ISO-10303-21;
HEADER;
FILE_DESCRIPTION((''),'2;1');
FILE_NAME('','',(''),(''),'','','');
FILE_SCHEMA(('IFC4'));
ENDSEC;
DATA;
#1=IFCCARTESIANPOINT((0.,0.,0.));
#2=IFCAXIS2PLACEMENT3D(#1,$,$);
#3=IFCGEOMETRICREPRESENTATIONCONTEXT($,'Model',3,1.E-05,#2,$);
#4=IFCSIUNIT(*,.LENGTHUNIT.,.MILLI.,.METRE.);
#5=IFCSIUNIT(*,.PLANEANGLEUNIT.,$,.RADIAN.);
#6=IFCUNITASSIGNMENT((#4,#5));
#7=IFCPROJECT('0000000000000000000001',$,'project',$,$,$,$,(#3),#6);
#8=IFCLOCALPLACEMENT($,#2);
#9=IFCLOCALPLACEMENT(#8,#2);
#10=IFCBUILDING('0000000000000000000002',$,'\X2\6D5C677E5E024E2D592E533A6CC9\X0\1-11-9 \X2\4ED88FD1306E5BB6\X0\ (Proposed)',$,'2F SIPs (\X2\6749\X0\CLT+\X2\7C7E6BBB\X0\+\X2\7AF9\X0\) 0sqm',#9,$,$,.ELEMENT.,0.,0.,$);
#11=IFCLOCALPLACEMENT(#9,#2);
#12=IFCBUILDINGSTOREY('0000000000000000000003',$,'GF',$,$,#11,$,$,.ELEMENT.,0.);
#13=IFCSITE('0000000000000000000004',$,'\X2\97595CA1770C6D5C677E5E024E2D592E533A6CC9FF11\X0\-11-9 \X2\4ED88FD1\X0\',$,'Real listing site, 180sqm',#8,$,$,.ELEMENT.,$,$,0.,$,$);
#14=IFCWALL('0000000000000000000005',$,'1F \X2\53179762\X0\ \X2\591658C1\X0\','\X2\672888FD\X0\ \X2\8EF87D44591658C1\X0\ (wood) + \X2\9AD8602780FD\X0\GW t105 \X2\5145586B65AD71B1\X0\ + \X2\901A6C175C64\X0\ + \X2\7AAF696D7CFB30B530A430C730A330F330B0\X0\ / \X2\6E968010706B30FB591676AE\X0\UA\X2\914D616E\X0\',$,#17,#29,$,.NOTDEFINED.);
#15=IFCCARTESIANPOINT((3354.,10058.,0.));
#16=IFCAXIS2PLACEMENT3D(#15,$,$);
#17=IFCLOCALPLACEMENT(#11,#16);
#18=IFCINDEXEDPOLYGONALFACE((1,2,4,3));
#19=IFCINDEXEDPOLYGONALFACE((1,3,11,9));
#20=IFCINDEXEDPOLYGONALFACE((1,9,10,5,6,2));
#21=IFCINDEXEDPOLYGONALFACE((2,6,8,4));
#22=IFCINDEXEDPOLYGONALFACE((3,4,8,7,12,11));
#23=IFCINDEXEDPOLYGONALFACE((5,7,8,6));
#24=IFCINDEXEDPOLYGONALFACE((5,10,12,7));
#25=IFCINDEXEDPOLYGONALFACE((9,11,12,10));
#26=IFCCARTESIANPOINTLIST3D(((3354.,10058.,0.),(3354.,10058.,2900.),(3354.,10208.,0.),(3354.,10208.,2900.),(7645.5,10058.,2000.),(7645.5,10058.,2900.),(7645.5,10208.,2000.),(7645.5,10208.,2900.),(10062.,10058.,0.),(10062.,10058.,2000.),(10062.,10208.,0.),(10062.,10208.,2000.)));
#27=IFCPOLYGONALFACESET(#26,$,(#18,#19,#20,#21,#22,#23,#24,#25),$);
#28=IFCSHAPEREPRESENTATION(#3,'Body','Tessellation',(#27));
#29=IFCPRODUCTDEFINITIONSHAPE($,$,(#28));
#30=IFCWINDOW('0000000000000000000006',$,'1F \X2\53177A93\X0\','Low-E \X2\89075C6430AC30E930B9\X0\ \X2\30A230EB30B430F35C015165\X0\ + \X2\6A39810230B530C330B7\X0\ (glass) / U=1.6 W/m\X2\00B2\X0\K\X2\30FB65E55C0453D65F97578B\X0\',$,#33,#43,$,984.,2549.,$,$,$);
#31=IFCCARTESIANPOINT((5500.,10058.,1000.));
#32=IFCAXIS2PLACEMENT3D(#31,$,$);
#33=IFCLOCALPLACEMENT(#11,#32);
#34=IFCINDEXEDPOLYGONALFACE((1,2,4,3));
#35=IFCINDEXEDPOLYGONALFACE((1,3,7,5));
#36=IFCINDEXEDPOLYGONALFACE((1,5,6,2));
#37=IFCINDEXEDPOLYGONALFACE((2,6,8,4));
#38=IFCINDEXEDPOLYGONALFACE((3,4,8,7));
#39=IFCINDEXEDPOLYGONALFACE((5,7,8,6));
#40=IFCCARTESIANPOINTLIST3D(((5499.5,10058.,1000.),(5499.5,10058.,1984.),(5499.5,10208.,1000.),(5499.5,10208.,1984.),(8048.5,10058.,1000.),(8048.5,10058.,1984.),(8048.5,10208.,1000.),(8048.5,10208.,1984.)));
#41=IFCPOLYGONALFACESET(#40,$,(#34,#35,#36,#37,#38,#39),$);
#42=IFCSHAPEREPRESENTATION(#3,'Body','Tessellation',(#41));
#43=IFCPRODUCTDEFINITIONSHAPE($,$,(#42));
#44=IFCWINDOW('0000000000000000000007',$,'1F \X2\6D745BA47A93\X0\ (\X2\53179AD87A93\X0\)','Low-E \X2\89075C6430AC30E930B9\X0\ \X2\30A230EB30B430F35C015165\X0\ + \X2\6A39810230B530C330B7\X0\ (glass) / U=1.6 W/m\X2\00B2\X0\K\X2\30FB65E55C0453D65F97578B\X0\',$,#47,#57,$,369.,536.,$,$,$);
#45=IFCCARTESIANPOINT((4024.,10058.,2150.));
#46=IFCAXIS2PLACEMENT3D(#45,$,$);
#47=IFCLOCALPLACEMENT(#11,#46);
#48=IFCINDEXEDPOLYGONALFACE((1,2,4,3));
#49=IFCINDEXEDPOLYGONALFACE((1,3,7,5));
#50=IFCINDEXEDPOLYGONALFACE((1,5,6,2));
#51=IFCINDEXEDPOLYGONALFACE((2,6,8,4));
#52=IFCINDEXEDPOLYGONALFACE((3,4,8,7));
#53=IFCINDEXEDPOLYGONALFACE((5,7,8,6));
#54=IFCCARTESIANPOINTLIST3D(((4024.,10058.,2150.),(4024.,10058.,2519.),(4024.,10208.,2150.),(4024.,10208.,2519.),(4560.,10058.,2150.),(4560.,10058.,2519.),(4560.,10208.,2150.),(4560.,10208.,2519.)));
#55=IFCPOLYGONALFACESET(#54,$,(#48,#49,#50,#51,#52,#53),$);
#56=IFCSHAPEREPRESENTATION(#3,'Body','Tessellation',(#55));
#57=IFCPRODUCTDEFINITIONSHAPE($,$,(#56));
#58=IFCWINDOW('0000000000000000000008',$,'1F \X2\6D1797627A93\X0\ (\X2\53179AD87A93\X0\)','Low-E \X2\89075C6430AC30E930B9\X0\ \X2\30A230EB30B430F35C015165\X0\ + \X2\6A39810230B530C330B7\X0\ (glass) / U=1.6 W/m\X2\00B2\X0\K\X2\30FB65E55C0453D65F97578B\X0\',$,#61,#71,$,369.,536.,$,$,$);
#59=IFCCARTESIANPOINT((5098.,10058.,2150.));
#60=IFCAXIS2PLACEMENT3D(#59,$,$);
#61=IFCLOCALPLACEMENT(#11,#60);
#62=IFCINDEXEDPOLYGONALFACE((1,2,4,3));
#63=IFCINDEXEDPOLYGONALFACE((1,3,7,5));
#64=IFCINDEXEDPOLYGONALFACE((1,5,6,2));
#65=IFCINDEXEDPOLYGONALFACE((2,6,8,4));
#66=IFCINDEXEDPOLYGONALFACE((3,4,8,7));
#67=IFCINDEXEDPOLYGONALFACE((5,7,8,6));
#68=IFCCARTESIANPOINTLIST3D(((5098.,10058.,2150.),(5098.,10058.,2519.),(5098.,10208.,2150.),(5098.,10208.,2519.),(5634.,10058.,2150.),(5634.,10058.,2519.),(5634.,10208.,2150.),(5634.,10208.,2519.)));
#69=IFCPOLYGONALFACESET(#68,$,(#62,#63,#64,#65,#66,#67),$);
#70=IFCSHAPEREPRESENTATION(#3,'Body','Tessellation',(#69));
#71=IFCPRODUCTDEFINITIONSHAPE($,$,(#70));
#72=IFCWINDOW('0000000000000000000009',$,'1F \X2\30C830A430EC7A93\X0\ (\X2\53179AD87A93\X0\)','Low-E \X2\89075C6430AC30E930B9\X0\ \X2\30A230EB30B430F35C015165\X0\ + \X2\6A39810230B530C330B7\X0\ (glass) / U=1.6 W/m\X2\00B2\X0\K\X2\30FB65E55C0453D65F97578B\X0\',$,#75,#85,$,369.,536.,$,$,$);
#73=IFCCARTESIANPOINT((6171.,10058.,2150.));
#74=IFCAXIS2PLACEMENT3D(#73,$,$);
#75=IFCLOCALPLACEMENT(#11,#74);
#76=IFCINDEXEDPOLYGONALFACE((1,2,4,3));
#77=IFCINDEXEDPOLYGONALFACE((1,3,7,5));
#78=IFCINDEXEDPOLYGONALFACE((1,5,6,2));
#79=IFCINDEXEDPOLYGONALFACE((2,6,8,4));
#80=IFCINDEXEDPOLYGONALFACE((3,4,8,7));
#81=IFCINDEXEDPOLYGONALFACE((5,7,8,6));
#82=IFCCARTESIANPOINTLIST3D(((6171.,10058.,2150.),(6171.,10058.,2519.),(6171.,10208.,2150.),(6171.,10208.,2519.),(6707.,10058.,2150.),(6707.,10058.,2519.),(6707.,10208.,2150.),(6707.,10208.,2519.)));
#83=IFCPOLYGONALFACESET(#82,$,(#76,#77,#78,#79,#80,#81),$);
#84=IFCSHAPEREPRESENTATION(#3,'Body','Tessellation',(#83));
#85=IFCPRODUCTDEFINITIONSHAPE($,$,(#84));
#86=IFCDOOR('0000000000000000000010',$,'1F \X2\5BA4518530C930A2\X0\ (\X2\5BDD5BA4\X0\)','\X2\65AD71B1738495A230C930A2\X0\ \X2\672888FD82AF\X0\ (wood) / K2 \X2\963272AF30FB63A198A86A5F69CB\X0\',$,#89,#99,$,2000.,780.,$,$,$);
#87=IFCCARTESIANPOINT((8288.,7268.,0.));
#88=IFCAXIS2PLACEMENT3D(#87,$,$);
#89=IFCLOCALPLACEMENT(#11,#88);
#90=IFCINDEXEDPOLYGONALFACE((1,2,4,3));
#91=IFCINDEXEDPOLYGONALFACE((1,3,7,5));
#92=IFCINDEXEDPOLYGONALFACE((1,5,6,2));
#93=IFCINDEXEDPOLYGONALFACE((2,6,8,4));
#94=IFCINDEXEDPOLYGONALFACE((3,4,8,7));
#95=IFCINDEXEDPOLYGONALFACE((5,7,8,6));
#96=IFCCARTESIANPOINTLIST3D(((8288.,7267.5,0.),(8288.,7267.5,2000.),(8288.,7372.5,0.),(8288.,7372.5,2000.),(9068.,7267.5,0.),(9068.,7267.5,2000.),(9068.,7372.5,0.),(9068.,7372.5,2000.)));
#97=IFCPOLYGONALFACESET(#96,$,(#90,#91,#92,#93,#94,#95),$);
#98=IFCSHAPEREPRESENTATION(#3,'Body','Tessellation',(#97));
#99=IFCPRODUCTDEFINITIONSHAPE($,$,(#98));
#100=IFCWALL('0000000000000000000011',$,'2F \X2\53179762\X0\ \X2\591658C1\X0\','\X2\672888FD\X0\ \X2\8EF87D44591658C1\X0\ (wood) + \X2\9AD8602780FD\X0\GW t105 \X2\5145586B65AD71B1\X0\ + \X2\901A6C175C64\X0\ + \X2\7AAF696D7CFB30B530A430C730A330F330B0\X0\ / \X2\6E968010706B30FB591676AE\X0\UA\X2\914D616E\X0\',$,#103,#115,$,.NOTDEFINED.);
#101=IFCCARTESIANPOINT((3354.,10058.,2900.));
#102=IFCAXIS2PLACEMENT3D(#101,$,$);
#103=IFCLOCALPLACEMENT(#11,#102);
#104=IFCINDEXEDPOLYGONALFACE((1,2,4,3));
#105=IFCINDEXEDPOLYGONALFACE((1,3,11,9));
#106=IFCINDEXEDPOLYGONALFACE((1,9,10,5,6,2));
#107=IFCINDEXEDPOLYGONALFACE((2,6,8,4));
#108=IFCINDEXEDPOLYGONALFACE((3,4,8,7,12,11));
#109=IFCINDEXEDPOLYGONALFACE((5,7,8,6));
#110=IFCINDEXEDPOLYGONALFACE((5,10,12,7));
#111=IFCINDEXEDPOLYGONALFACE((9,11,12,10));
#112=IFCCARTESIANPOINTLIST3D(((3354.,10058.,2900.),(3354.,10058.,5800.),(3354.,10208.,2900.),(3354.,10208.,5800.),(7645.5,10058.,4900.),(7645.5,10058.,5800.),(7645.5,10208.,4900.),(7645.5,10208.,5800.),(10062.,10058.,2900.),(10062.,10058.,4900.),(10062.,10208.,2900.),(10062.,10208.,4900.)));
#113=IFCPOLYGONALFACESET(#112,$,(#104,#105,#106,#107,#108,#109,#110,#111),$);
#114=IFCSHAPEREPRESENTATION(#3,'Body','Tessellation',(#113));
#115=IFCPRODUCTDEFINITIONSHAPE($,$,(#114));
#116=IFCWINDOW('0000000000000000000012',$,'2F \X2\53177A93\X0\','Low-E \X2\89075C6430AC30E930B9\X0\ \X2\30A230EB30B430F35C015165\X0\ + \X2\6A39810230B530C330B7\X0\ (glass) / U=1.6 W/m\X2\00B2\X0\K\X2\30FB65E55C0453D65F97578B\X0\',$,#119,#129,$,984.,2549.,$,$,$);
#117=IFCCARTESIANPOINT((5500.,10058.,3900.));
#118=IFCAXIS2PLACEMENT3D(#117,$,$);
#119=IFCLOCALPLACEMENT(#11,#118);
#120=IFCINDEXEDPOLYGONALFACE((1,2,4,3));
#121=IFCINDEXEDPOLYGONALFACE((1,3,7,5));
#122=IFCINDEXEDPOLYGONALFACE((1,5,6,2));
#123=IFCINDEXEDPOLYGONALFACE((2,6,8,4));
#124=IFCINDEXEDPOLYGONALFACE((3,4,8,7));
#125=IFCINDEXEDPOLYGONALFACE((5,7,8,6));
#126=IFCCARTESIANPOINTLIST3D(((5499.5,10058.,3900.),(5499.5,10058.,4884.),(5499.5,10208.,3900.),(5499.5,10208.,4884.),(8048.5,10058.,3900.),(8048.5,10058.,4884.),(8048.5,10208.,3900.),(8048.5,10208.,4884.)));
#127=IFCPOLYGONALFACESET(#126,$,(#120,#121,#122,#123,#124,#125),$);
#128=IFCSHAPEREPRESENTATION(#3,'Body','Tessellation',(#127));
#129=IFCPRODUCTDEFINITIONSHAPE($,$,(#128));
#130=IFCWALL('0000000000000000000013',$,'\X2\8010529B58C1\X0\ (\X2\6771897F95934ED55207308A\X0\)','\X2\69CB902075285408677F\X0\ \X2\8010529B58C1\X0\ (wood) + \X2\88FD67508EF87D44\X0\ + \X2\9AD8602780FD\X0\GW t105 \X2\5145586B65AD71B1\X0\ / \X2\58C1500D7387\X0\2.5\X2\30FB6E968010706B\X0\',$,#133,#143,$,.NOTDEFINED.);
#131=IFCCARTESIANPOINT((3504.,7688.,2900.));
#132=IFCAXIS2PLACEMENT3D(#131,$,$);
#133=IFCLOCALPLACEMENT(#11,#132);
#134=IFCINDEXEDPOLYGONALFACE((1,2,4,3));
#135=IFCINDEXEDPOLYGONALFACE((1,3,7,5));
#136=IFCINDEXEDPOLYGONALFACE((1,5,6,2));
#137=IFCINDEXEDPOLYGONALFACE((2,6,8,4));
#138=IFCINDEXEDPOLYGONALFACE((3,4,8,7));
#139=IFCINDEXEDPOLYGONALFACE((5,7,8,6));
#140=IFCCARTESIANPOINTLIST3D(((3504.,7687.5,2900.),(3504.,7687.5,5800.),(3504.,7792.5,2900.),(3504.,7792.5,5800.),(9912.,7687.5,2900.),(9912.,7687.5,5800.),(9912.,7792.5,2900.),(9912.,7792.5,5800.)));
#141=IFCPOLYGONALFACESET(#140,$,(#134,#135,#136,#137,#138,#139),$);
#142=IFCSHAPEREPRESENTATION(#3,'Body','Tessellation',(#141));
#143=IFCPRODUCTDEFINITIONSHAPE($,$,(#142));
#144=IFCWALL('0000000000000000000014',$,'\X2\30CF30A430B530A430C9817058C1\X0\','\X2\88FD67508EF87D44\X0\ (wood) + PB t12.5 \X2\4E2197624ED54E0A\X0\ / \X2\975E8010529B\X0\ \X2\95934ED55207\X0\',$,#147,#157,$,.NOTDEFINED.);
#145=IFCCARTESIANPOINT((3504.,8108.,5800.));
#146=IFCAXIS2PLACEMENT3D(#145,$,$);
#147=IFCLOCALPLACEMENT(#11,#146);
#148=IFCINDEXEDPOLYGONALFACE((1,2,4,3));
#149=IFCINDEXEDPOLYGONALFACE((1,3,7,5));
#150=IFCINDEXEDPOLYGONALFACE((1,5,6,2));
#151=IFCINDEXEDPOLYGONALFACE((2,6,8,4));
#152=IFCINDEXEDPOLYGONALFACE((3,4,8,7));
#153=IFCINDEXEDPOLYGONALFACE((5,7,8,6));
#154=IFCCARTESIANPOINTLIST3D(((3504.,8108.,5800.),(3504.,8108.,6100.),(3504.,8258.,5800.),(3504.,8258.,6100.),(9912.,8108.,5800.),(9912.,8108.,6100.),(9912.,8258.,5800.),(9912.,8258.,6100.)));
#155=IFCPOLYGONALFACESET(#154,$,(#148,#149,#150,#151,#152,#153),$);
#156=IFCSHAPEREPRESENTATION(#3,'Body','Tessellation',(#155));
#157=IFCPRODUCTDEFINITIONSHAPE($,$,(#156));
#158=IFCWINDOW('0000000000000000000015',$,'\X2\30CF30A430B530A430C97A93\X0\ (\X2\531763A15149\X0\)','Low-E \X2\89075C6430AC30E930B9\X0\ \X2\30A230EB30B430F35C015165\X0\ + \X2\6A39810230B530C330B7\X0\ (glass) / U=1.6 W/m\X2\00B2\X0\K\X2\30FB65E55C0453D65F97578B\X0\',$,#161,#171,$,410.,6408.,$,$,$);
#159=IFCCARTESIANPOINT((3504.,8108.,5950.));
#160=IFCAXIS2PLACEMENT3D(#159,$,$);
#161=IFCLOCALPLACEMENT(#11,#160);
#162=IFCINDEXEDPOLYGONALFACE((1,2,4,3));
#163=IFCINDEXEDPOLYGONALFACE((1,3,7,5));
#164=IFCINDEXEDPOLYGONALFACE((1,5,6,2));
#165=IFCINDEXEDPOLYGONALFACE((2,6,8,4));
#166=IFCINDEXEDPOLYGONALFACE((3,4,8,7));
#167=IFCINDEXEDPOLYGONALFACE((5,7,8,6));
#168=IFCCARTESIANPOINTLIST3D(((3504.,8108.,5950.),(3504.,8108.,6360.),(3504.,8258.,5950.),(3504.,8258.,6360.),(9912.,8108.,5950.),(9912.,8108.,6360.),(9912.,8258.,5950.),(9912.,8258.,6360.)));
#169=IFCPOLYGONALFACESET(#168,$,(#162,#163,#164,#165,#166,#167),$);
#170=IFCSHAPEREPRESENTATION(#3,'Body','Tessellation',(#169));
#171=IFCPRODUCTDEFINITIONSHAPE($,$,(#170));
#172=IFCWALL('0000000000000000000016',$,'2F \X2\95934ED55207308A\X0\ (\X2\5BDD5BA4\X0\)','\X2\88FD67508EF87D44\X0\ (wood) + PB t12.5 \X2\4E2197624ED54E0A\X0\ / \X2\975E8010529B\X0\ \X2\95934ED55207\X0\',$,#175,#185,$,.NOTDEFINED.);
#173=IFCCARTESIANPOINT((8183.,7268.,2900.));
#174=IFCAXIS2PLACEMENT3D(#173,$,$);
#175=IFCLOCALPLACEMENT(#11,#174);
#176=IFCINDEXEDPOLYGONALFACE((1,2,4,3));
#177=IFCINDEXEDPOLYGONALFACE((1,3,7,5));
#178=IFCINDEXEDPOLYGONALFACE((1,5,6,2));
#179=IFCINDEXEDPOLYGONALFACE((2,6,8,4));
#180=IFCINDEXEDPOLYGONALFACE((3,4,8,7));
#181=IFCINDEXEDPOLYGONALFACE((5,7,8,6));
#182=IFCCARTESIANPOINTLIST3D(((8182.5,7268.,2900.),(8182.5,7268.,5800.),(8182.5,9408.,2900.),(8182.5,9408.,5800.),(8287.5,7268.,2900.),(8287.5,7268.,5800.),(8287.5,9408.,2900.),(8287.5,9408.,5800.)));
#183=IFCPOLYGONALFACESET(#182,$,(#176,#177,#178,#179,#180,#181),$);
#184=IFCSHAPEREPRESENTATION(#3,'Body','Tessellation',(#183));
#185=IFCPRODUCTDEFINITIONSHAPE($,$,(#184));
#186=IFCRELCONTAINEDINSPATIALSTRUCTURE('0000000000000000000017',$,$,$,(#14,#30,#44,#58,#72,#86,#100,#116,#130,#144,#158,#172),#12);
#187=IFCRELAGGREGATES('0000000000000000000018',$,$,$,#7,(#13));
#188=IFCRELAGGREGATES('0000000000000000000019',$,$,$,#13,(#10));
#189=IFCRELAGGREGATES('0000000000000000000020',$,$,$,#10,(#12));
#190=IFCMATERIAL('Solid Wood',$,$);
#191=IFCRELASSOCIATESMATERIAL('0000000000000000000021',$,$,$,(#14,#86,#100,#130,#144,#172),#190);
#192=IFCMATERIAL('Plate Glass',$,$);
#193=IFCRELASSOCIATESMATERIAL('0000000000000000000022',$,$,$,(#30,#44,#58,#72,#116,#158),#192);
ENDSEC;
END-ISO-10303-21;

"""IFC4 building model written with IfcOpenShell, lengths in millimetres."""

from ifc_helpers import new_model, si_unit, frame, frame_2d, origin, place, context, project, spatial, rectangle, extrude, material, element, fill, save


model = new_model("IFC4")

# Units and contexts
model_context = context("Model", 3, precision=1e-05, world=origin())
ifc_project = project(units=[si_unit("LENGTHUNIT", "METRE", prefix="MILLI"), si_unit("PLANEANGLEUNIT", "RADIAN")], contexts=[model_context])

# Site, building, storey
site_placement = place(None, origin())
site = spatial("IfcSite", under=ifc_project, at=site_placement, Name="静岡県浜松市中央区泉１-11-9 付近", ObjectType="Real listing site, 180sqm", CompositionType="ELEMENT", RefElevation=0.0)
building_placement = place(site_placement, origin())
building = spatial("IfcBuilding", under=site, at=building_placement, Name="浜松市中央区泉1-11-9 付近の家 (Proposed)", ObjectType="2F SIPs (杉CLT+籾殻+竹) 0sqm", CompositionType="ELEMENT", ElevationOfRefHeight=0.0, ElevationOfTerrain=0.0)
storey_placement = place(building_placement, origin())
storey = spatial("IfcBuildingStorey", under=building, at=storey_placement, Name="GF", CompositionType="ELEMENT", Elevation=0.0)

# Wall, openings, windows
ifc_material_1 = material(Name="Solid Wood")
wall_1_placement = place(storey_placement, frame((3354.0, 10058.0, 0.0)))
wall_1 = element("IfcWall", 1, at=wall_1_placement, inside=storey, material=ifc_material_1, Name="1F 北面 外壁", Description="木製 軸組外壁 (wood) + 高性能GW t105 充填断熱 + 通気層 + 窯業系サイディング / 準耐火・外皮UA配慮", PredefinedType="NOTDEFINED", context=model_context, shape_type="SweptSolid", body=[
    extrude(rectangle(XDim=6708.0, YDim=150.0, at=frame_2d((3354.0, 75.0))), frame((3354.0, 10058.0, 0.0)), (0.0, 0.0, 1.0), 2900.0),
])
opening_1_placement = place(storey_placement, frame((5500.0, 10058.0, 1000.0)))
opening_1 = element("IfcOpeningElement", 2, at=opening_1_placement, cuts=wall_1, PredefinedType="NOTDEFINED", context=model_context, shape_type="SweptSolid", body=[
    extrude(rectangle(XDim=2549.0, YDim=150.0, at=frame_2d((1274.0, 75.0))), frame((5500.0, 10058.0, 1000.0)), (0.0, 0.0, 1.0), 984.0),
])
opening_2_placement = place(storey_placement, frame((4024.0, 10058.0, 2150.0)))
opening_2 = element("IfcOpeningElement", 3, at=opening_2_placement, cuts=wall_1, PredefinedType="NOTDEFINED", context=model_context, shape_type="SweptSolid", body=[
    extrude(rectangle(XDim=536.0, YDim=150.0, at=frame_2d((268.0, 75.0))), frame((4024.0, 10058.0, 2150.0)), (0.0, 0.0, 1.0), 369.0),
])
opening_3_placement = place(storey_placement, frame((5098.0, 10058.0, 2150.0)))
opening_3 = element("IfcOpeningElement", 4, at=opening_3_placement, cuts=wall_1, PredefinedType="NOTDEFINED", context=model_context, shape_type="SweptSolid", body=[
    extrude(rectangle(XDim=536.0, YDim=150.0, at=frame_2d((268.0, 75.0))), frame((5098.0, 10058.0, 2150.0)), (0.0, 0.0, 1.0), 369.0),
])
opening_4_placement = place(storey_placement, frame((6171.0, 10058.0, 2150.0)))
opening_4 = element("IfcOpeningElement", 5, at=opening_4_placement, cuts=wall_1, PredefinedType="NOTDEFINED", context=model_context, shape_type="SweptSolid", body=[
    extrude(rectangle(XDim=536.0, YDim=150.0, at=frame_2d((268.0, 75.0))), frame((6171.0, 10058.0, 2150.0)), (0.0, 0.0, 1.0), 369.0),
])
ifc_material_2 = material(Name="Plate Glass")
window_1_placement = place(storey_placement, frame((5500.0, 10058.0, 1000.0)))
window_1 = element("IfcWindow", 6, at=window_1_placement, inside=storey, material=ifc_material_2, Name="1F 北窓", Description="Low-E 複層ガラス アルゴン封入 + 樹脂サッシ (glass) / U=1.6 W/m²K・日射取得型", OverallHeight=984.0, OverallWidth=2549.0, context=model_context, shape_type="SweptSolid", body=[
    extrude(rectangle(XDim=2549.0, YDim=150.0, at=frame_2d((1274.0, 75.0))), frame((5500.0, 10058.0, 1000.0)), (0.0, 0.0, 1.0), 984.0),
])
fill(opening_1, window_1)
window_2_placement = place(storey_placement, frame((4024.0, 10058.0, 2150.0)))
window_2 = element("IfcWindow", 7, at=window_2_placement, inside=storey, material=ifc_material_2, Name="1F 浴室窓 (北高窓)", Description="Low-E 複層ガラス アルゴン封入 + 樹脂サッシ (glass) / U=1.6 W/m²K・日射取得型", OverallHeight=369.0, OverallWidth=536.0, context=model_context, shape_type="SweptSolid", body=[
    extrude(rectangle(XDim=536.0, YDim=150.0, at=frame_2d((268.0, 75.0))), frame((4024.0, 10058.0, 2150.0)), (0.0, 0.0, 1.0), 369.0),
])
fill(opening_2, window_2)
window_3_placement = place(storey_placement, frame((5098.0, 10058.0, 2150.0)))
window_3 = element("IfcWindow", 8, at=window_3_placement, inside=storey, material=ifc_material_2, Name="1F 洗面窓 (北高窓)", Description="Low-E 複層ガラス アルゴン封入 + 樹脂サッシ (glass) / U=1.6 W/m²K・日射取得型", OverallHeight=369.0, OverallWidth=536.0, context=model_context, shape_type="SweptSolid", body=[
    extrude(rectangle(XDim=536.0, YDim=150.0, at=frame_2d((268.0, 75.0))), frame((5098.0, 10058.0, 2150.0)), (0.0, 0.0, 1.0), 369.0),
])
fill(opening_3, window_3)
window_4_placement = place(storey_placement, frame((6171.0, 10058.0, 2150.0)))
window_4 = element("IfcWindow", 9, at=window_4_placement, inside=storey, material=ifc_material_2, Name="1F トイレ窓 (北高窓)", Description="Low-E 複層ガラス アルゴン封入 + 樹脂サッシ (glass) / U=1.6 W/m²K・日射取得型", OverallHeight=369.0, OverallWidth=536.0, context=model_context, shape_type="SweptSolid", body=[
    extrude(rectangle(XDim=536.0, YDim=150.0, at=frame_2d((268.0, 75.0))), frame((6171.0, 10058.0, 2150.0)), (0.0, 0.0, 1.0), 369.0),
])
fill(opening_4, window_4)

# Door
door_1_placement = place(storey_placement, frame((8288.0, 7268.0, 0.0)))
element("IfcDoor", 10, at=door_1_placement, inside=storey, material=ifc_material_1, Name="1F 室内ドア (寝室)", Description="断熱玄関ドア 木製芯 (wood) / K2 防犯・採風機構", OverallHeight=2000.0, OverallWidth=780.0, context=model_context, shape_type="SweptSolid", body=[
    extrude(rectangle(XDim=780.0, YDim=105.0, at=frame_2d((390.0, 52.0))), frame((8288.0, 7268.0, 0.0)), (0.0, 0.0, 1.0), 2000.0),
])

# Wall, opening, window
wall_2_placement = place(storey_placement, frame((3354.0, 10058.0, 2900.0)))
wall_2 = element("IfcWall", 11, at=wall_2_placement, inside=storey, material=ifc_material_1, Name="2F 北面 外壁", Description="木製 軸組外壁 (wood) + 高性能GW t105 充填断熱 + 通気層 + 窯業系サイディング / 準耐火・外皮UA配慮", PredefinedType="NOTDEFINED", context=model_context, shape_type="SweptSolid", body=[
    extrude(rectangle(XDim=6708.0, YDim=150.0, at=frame_2d((3354.0, 75.0))), frame((3354.0, 10058.0, 2900.0)), (0.0, 0.0, 1.0), 2900.0),
])
opening_5_placement = place(storey_placement, frame((5500.0, 10058.0, 3900.0)))
opening_5 = element("IfcOpeningElement", 12, at=opening_5_placement, cuts=wall_2, PredefinedType="NOTDEFINED", context=model_context, shape_type="SweptSolid", body=[
    extrude(rectangle(XDim=2549.0, YDim=150.0, at=frame_2d((1274.0, 75.0))), frame((5500.0, 10058.0, 3900.0)), (0.0, 0.0, 1.0), 984.0),
])
window_5_placement = place(storey_placement, frame((5500.0, 10058.0, 3900.0)))
window_5 = element("IfcWindow", 13, at=window_5_placement, inside=storey, material=ifc_material_2, Name="2F 北窓", Description="Low-E 複層ガラス アルゴン封入 + 樹脂サッシ (glass) / U=1.6 W/m²K・日射取得型", OverallHeight=984.0, OverallWidth=2549.0, context=model_context, shape_type="SweptSolid", body=[
    extrude(rectangle(XDim=2549.0, YDim=150.0, at=frame_2d((1274.0, 75.0))), frame((5500.0, 10058.0, 3900.0)), (0.0, 0.0, 1.0), 984.0),
])
fill(opening_5, window_5)

# Wall
wall_3_placement = place(storey_placement, frame((3504.0, 7688.0, 2900.0)))
element("IfcWall", 14, at=wall_3_placement, inside=storey, material=ifc_material_1, Name="耐力壁 (東西間仕切り)", Description="構造用合板 耐力壁 (wood) + 製材軸組 + 高性能GW t105 充填断熱 / 壁倍率2.5・準耐火", PredefinedType="NOTDEFINED", context=model_context, shape_type="SweptSolid", body=[
    extrude(rectangle(XDim=6408.0, YDim=105.0, at=frame_2d((3204.0, 52.0))), frame((3504.0, 7688.0, 2900.0)), (0.0, 0.0, 1.0), 2900.0),
])

# Wall, opening, window
wall_4_placement = place(storey_placement, frame((3504.0, 8108.0, 5800.0)))
wall_4 = element("IfcWall", 15, at=wall_4_placement, inside=storey, material=ifc_material_1, Name="ハイサイド腰壁", Description="製材軸組 (wood) + PB t12.5 両面仕上 / 非耐力 間仕切", PredefinedType="NOTDEFINED", context=model_context, shape_type="SweptSolid", body=[
    extrude(rectangle(XDim=6408.0, YDim=150.0, at=frame_2d((3204.0, 75.0))), frame((3504.0, 8108.0, 5800.0)), (0.0, 0.0, 1.0), 700.0),
])
opening_6_placement = place(storey_placement, frame((3504.0, 8108.0, 5950.0)))
opening_6 = element("IfcOpeningElement", 16, at=opening_6_placement, cuts=wall_4, PredefinedType="NOTDEFINED", context=model_context, shape_type="SweptSolid", body=[
    extrude(rectangle(XDim=6408.0, YDim=150.0, at=frame_2d((3204.0, 75.0))), frame((3504.0, 8108.0, 5950.0)), (0.0, 0.0, 1.0), 410.0),
])
window_6_placement = place(storey_placement, frame((3504.0, 8108.0, 5950.0)))
window_6 = element("IfcWindow", 17, at=window_6_placement, inside=storey, material=ifc_material_2, Name="ハイサイド窓 (北採光)", Description="Low-E 複層ガラス アルゴン封入 + 樹脂サッシ (glass) / U=1.6 W/m²K・日射取得型", OverallHeight=410.0, OverallWidth=6408.0, context=model_context, shape_type="SweptSolid", body=[
    extrude(rectangle(XDim=6408.0, YDim=150.0, at=frame_2d((3204.0, 75.0))), frame((3504.0, 8108.0, 5950.0)), (0.0, 0.0, 1.0), 410.0),
])
fill(opening_6, window_6)

# Wall
wall_5_placement = place(storey_placement, frame((8183.0, 7268.0, 2900.0)))
element("IfcWall", 18, at=wall_5_placement, inside=storey, material=ifc_material_1, Name="2F 間仕切り (寝室)", Description="製材軸組 (wood) + PB t12.5 両面仕上 / 非耐力 間仕切", PredefinedType="NOTDEFINED", context=model_context, shape_type="SweptSolid", body=[
    extrude(rectangle(XDim=105.0, YDim=2140.0, at=frame_2d((52.0, 1070.0))), frame((8183.0, 7268.0, 2900.0)), (0.0, 0.0, 1.0), 2900.0),
])

save(model, "model.ifc")
